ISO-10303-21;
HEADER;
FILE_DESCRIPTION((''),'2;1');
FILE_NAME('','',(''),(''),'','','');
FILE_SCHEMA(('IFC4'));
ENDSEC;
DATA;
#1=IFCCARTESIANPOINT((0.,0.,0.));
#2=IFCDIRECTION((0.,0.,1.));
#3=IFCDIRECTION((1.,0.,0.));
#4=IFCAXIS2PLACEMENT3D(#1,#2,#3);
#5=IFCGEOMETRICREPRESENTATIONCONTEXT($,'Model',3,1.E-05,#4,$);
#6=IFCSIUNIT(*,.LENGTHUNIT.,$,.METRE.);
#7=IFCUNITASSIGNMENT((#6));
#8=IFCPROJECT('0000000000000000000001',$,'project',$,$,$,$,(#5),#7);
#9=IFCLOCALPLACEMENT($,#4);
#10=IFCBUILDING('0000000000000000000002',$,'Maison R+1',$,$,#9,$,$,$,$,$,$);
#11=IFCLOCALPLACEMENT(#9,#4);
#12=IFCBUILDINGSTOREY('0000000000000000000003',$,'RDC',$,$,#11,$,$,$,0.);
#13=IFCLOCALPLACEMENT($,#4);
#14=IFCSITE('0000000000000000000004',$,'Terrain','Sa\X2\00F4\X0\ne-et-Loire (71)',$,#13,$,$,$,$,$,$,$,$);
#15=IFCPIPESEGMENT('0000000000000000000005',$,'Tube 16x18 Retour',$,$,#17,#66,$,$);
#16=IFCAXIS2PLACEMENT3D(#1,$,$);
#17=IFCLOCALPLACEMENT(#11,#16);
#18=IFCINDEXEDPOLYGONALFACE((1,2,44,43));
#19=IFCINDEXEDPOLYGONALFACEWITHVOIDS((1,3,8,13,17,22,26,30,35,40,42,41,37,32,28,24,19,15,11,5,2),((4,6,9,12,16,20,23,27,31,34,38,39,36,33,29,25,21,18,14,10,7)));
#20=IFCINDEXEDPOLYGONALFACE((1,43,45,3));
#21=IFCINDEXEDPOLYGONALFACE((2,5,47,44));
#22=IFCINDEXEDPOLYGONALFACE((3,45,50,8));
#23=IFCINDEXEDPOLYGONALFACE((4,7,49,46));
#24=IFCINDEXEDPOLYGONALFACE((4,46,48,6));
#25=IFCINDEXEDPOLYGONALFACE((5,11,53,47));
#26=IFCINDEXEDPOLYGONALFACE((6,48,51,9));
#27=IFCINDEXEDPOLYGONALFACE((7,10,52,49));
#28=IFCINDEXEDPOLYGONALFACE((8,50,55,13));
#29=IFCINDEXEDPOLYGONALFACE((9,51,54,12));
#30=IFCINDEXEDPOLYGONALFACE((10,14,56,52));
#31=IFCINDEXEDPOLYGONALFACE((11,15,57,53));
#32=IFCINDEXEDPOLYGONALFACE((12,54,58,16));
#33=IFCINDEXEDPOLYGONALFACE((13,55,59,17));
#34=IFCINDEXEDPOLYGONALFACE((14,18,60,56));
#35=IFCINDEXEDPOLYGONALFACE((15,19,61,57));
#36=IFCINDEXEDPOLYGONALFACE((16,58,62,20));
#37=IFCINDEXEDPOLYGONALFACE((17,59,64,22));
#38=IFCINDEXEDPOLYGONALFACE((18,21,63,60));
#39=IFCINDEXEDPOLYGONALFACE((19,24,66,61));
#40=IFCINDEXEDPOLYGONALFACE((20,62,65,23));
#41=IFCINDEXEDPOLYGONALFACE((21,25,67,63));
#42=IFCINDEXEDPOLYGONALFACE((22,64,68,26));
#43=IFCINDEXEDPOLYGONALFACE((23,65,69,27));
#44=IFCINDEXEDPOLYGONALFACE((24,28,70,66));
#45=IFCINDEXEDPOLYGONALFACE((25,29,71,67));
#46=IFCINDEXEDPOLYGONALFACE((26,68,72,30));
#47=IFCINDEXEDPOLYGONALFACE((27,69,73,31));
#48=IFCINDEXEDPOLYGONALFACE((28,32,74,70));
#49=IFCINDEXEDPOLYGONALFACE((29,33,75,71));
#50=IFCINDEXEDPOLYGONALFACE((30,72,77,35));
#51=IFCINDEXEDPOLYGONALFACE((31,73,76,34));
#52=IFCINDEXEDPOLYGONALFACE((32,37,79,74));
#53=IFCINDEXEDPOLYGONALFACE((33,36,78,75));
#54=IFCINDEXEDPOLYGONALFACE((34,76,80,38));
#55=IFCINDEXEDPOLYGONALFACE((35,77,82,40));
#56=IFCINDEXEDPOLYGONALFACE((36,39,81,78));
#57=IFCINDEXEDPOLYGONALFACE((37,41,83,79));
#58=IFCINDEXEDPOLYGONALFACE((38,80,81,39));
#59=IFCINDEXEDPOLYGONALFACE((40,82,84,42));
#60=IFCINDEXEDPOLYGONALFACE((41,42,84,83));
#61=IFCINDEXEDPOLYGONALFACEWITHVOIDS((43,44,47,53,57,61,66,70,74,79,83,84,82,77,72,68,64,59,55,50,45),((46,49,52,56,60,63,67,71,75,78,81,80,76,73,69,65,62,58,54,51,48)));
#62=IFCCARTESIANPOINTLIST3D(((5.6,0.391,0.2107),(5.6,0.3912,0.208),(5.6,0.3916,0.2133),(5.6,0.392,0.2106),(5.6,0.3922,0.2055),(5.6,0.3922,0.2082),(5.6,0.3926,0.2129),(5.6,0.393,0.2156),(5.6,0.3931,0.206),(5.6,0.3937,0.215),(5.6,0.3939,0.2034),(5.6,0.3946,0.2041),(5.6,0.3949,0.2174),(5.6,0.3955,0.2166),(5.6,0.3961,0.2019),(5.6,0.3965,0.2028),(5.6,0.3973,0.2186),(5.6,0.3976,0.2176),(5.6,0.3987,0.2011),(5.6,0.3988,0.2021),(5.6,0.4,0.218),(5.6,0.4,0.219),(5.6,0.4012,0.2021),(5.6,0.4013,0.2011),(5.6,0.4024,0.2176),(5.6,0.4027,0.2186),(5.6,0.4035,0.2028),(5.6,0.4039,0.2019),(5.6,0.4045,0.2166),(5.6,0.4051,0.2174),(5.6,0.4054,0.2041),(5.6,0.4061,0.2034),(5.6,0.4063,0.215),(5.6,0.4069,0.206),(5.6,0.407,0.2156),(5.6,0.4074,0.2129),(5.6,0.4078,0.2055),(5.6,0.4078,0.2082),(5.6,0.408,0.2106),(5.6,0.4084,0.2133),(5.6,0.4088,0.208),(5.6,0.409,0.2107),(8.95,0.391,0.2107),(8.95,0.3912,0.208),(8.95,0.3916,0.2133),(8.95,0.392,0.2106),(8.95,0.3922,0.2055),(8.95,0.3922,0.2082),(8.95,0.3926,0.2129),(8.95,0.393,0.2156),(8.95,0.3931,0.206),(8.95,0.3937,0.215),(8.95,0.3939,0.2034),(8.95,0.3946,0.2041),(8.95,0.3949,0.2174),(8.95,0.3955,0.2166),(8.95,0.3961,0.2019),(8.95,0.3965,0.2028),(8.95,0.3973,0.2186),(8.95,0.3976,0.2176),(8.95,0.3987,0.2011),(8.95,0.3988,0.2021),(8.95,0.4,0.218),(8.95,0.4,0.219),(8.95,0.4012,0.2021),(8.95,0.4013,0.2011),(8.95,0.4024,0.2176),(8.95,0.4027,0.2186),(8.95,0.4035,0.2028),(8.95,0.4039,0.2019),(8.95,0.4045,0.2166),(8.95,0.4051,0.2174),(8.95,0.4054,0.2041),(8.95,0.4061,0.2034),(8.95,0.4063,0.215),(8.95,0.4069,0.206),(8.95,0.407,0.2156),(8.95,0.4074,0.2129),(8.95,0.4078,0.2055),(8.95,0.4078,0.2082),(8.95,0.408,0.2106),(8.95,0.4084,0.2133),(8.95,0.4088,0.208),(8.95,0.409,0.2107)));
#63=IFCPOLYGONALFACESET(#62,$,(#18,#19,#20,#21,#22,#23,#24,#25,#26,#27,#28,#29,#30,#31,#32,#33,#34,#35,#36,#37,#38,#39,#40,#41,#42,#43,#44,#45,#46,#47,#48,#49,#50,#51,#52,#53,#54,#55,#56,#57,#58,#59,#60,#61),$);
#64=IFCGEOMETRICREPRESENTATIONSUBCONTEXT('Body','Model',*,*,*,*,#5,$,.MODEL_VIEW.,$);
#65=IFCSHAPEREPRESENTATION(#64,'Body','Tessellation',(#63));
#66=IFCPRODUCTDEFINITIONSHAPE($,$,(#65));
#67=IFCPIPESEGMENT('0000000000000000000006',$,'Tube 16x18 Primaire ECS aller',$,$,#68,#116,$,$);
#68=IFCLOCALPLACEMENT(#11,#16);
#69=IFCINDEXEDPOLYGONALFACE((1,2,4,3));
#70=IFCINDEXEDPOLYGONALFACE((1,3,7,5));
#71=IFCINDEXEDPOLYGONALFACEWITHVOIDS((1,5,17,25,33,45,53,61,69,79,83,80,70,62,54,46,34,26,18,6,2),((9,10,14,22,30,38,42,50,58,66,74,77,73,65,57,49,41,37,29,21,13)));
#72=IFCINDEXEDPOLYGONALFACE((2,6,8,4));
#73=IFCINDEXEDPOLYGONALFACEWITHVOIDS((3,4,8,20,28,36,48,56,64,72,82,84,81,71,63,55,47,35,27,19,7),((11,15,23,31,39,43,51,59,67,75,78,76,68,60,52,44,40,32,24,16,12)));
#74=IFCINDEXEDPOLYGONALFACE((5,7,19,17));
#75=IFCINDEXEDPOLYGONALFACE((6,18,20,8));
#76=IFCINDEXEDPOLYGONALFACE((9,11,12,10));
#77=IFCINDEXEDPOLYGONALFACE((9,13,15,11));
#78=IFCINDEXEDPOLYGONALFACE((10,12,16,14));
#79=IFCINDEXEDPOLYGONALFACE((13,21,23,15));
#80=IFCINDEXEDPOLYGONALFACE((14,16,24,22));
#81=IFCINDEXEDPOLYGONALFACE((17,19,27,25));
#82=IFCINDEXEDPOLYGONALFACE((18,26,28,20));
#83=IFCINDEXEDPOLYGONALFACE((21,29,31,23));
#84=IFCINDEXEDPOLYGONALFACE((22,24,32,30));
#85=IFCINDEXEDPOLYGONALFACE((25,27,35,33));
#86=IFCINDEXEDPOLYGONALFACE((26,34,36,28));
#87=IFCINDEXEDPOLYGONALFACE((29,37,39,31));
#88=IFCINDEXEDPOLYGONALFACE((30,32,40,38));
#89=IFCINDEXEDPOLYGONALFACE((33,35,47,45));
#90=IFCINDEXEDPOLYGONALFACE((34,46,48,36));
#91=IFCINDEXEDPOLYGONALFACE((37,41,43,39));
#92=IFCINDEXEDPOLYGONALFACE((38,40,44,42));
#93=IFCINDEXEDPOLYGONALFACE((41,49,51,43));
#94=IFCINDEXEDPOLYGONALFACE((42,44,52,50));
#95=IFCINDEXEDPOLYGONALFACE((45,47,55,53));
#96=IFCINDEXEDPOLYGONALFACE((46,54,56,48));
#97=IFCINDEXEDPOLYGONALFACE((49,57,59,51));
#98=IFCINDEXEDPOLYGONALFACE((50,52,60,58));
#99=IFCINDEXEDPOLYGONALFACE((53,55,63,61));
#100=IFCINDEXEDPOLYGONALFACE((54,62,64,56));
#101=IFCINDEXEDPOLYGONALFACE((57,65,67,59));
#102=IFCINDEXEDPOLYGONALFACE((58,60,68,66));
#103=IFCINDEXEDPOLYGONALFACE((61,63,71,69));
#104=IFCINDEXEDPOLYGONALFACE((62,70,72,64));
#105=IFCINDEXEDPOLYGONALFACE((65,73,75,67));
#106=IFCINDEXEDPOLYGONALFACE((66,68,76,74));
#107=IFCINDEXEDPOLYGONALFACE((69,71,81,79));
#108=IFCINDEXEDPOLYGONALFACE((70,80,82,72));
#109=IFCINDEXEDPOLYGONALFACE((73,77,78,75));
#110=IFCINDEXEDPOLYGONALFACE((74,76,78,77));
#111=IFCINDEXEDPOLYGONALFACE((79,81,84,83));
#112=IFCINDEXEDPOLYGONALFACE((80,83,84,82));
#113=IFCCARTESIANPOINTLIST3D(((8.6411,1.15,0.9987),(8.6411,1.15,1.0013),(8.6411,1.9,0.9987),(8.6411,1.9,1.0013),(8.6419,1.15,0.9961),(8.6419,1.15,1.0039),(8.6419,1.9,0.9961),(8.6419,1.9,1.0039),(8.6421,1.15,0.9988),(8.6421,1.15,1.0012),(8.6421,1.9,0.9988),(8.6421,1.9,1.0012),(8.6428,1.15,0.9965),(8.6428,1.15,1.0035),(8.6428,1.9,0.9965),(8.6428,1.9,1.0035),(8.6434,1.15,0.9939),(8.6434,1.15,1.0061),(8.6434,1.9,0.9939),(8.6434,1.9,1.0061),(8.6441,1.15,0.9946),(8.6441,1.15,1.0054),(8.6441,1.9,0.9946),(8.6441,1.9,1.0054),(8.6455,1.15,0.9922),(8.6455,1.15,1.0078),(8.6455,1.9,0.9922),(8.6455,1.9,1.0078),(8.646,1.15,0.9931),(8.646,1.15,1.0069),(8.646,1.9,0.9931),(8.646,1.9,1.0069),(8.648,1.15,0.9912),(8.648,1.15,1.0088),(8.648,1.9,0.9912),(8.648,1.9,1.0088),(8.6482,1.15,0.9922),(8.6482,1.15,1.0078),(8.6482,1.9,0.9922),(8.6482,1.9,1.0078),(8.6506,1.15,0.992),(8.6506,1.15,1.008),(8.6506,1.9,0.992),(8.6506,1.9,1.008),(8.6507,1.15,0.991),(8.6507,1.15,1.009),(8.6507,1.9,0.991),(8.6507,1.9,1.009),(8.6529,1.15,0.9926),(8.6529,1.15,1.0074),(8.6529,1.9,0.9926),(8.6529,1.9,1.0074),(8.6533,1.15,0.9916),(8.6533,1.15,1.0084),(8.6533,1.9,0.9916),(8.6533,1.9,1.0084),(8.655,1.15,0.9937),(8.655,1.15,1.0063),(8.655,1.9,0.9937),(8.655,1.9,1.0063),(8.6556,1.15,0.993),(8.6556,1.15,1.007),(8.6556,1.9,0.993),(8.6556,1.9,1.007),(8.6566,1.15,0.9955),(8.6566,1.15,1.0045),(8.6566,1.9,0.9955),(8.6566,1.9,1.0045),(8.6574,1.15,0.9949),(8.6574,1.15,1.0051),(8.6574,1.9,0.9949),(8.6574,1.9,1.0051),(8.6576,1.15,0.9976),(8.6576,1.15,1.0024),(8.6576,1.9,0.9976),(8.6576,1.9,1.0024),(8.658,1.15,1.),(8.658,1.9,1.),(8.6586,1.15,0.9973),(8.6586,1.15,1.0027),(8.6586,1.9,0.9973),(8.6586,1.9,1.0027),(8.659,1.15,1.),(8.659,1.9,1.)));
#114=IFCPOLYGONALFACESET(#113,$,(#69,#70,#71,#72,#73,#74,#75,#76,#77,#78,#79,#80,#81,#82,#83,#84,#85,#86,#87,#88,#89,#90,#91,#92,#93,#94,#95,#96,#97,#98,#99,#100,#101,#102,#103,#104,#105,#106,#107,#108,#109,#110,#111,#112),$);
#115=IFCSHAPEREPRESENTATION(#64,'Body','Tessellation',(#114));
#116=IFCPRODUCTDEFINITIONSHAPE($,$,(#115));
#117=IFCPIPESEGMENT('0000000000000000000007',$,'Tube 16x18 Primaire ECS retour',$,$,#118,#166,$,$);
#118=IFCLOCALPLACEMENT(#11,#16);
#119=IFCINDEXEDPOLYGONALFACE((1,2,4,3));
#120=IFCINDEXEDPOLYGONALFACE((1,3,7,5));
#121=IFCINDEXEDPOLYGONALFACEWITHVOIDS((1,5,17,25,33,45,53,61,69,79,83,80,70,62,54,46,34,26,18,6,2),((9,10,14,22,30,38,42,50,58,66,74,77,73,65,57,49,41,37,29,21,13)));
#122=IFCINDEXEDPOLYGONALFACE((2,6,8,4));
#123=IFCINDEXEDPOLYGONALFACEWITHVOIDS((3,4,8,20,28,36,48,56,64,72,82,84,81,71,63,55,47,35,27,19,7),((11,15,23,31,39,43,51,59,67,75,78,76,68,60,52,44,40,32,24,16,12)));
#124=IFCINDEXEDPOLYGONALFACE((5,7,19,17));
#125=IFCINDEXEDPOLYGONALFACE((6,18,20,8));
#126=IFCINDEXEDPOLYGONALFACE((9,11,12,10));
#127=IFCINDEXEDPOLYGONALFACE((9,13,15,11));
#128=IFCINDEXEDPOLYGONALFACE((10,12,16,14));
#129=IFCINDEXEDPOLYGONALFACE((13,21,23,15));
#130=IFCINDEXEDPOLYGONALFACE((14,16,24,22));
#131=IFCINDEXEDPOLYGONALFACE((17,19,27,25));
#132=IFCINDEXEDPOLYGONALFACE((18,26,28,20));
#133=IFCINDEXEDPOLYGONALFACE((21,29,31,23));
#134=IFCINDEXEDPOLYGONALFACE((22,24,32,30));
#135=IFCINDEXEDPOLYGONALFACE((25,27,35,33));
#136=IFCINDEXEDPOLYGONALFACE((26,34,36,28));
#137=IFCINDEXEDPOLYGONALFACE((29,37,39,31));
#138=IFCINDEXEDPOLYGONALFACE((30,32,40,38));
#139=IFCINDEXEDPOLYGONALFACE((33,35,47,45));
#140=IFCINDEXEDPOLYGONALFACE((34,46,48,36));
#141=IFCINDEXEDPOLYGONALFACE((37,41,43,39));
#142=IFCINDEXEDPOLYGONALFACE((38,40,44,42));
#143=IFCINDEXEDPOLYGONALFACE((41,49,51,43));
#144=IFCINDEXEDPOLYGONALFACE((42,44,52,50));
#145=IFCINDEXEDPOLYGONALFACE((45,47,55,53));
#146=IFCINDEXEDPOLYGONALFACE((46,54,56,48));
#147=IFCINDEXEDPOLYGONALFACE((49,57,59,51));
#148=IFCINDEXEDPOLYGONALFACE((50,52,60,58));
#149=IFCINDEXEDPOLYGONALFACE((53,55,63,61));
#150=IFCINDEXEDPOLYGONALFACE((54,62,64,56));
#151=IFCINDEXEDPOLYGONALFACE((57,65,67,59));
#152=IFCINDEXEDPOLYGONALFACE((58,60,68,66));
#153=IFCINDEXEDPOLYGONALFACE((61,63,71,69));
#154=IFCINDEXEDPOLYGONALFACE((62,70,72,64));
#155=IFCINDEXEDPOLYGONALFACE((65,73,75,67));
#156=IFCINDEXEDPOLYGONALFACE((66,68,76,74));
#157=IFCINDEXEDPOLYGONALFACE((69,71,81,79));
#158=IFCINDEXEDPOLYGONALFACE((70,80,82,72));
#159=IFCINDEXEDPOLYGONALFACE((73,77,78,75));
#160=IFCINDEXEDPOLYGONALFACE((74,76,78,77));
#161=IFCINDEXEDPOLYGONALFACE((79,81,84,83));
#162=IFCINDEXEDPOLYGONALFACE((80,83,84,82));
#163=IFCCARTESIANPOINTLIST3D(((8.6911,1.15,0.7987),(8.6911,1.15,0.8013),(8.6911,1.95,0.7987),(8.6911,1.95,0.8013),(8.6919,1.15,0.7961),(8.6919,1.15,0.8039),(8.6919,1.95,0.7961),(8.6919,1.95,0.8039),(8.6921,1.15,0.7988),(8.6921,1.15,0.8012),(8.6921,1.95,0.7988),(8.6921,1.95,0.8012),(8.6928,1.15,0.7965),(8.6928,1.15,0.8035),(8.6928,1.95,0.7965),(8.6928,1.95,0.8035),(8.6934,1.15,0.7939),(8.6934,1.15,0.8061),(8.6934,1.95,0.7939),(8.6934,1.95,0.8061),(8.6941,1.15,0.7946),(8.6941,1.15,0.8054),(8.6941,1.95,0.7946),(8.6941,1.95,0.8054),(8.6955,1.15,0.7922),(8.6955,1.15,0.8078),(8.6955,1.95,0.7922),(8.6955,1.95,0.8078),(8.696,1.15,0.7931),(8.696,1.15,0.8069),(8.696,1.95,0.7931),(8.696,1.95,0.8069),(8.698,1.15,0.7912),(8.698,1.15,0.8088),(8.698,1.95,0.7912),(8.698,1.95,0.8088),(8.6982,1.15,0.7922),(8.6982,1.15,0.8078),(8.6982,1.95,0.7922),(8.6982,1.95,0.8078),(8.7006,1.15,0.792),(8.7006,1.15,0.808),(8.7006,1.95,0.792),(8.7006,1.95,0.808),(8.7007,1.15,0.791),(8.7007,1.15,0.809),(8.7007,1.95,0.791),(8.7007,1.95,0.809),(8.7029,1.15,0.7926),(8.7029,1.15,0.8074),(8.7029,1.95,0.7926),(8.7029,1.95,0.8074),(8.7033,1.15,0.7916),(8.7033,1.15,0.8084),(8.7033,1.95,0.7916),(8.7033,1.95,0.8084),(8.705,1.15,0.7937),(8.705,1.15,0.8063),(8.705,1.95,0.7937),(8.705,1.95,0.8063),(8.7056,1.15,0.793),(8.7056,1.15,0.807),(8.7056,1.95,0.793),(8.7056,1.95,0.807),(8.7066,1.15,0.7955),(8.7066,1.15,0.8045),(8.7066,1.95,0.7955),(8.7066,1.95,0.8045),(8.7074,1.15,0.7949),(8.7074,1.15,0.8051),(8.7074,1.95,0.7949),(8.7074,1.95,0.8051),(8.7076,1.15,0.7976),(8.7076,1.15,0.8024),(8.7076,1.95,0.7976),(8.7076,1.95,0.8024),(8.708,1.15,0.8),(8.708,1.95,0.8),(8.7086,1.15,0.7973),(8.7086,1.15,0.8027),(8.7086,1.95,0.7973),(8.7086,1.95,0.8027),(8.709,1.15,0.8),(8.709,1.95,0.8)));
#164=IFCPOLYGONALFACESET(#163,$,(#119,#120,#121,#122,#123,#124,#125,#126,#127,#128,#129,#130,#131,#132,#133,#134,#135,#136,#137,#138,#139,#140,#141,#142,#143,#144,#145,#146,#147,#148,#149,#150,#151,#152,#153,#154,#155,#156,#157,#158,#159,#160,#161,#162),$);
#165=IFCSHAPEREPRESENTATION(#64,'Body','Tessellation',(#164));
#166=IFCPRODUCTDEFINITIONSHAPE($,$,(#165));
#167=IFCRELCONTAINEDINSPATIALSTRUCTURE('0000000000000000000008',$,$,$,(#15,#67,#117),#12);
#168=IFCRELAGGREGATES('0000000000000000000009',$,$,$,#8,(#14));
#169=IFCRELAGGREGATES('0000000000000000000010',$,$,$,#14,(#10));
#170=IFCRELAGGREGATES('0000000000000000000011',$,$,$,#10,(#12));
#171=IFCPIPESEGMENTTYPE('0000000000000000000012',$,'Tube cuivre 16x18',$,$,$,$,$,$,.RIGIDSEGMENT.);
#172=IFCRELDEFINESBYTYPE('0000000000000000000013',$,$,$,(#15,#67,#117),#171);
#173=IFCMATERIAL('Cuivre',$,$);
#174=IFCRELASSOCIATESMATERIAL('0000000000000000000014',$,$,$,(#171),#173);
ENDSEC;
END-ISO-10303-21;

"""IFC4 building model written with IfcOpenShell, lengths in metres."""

from ifc_helpers import new_model, si_unit, frame, origin_with_axes, place, context, subcontext, project, spatial, hollow_circle, extrude, material, type_object, element, save


model = new_model("IFC4")

# Units and contexts
model_context = context("Model", 3, precision=1e-05, world=origin_with_axes())
body_context = subcontext(model_context, "Body", "Model", "MODEL_VIEW")
ifc_project = project(units=[si_unit("LENGTHUNIT", "METRE")], contexts=[model_context])

# Site, building, storey
site_placement = place(None, origin_with_axes())
site = spatial("IfcSite", under=ifc_project, at=site_placement, Name="Terrain", Description="Saône-et-Loire (71)")
building_placement = place(None, origin_with_axes())
building = spatial("IfcBuilding", under=site, at=building_placement, Name="Maison R+1")
storey_placement = place(building_placement, origin_with_axes())
storey = spatial("IfcBuildingStorey", under=building, at=storey_placement, Name="RDC", Elevation=0.0)

# Pipe segments
ifc_material_1 = material(Name="Cuivre")
pipe_segment_type_1 = type_object("IfcPipeSegmentType", Name="Tube cuivre 16x18", PredefinedType="RIGIDSEGMENT", material=ifc_material_1)
pipe_segment_1_placement = place(storey_placement, frame((8.95, 0.4, 0.21), z_axis=(-1.0, 0.0, 0.0), x_axis=(0.0, 0.0, 1.0)))
element("IfcPipeSegment", 1, at=pipe_segment_1_placement, inside=storey, type_object=pipe_segment_type_1, Name="Tube 16x18 Retour", context=body_context, shape_type="SweptSolid", body=[
    extrude(hollow_circle(Radius=0.009, WallThickness=0.001), origin_with_axes(), (0.0, 0.0, 1.0), 3.35),
])
pipe_segment_2_placement = place(storey_placement, frame((8.65, 1.15, 1.0), z_axis=(0.0, 1.0, 0.0), x_axis=(1.0, 0.0, 0.0)))
element("IfcPipeSegment", 2, at=pipe_segment_2_placement, inside=storey, type_object=pipe_segment_type_1, Name="Tube 16x18 Primaire ECS aller", context=body_context, shape_type="SweptSolid", body=[
    extrude(hollow_circle(Radius=0.009, WallThickness=0.001), origin_with_axes(), (0.0, 0.0, 1.0), 0.75),
])
pipe_segment_3_placement = place(storey_placement, frame((8.7, 1.15, 0.8), z_axis=(0.0, 1.0, 0.0), x_axis=(1.0, 0.0, 0.0)))
element("IfcPipeSegment", 3, at=pipe_segment_3_placement, inside=storey, type_object=pipe_segment_type_1, Name="Tube 16x18 Primaire ECS retour", context=body_context, shape_type="SweptSolid", body=[
    extrude(hollow_circle(Radius=0.009, WallThickness=0.001), origin_with_axes(), (0.0, 0.0, 1.0), 0.8),
])

save(model, "model.ifc")
